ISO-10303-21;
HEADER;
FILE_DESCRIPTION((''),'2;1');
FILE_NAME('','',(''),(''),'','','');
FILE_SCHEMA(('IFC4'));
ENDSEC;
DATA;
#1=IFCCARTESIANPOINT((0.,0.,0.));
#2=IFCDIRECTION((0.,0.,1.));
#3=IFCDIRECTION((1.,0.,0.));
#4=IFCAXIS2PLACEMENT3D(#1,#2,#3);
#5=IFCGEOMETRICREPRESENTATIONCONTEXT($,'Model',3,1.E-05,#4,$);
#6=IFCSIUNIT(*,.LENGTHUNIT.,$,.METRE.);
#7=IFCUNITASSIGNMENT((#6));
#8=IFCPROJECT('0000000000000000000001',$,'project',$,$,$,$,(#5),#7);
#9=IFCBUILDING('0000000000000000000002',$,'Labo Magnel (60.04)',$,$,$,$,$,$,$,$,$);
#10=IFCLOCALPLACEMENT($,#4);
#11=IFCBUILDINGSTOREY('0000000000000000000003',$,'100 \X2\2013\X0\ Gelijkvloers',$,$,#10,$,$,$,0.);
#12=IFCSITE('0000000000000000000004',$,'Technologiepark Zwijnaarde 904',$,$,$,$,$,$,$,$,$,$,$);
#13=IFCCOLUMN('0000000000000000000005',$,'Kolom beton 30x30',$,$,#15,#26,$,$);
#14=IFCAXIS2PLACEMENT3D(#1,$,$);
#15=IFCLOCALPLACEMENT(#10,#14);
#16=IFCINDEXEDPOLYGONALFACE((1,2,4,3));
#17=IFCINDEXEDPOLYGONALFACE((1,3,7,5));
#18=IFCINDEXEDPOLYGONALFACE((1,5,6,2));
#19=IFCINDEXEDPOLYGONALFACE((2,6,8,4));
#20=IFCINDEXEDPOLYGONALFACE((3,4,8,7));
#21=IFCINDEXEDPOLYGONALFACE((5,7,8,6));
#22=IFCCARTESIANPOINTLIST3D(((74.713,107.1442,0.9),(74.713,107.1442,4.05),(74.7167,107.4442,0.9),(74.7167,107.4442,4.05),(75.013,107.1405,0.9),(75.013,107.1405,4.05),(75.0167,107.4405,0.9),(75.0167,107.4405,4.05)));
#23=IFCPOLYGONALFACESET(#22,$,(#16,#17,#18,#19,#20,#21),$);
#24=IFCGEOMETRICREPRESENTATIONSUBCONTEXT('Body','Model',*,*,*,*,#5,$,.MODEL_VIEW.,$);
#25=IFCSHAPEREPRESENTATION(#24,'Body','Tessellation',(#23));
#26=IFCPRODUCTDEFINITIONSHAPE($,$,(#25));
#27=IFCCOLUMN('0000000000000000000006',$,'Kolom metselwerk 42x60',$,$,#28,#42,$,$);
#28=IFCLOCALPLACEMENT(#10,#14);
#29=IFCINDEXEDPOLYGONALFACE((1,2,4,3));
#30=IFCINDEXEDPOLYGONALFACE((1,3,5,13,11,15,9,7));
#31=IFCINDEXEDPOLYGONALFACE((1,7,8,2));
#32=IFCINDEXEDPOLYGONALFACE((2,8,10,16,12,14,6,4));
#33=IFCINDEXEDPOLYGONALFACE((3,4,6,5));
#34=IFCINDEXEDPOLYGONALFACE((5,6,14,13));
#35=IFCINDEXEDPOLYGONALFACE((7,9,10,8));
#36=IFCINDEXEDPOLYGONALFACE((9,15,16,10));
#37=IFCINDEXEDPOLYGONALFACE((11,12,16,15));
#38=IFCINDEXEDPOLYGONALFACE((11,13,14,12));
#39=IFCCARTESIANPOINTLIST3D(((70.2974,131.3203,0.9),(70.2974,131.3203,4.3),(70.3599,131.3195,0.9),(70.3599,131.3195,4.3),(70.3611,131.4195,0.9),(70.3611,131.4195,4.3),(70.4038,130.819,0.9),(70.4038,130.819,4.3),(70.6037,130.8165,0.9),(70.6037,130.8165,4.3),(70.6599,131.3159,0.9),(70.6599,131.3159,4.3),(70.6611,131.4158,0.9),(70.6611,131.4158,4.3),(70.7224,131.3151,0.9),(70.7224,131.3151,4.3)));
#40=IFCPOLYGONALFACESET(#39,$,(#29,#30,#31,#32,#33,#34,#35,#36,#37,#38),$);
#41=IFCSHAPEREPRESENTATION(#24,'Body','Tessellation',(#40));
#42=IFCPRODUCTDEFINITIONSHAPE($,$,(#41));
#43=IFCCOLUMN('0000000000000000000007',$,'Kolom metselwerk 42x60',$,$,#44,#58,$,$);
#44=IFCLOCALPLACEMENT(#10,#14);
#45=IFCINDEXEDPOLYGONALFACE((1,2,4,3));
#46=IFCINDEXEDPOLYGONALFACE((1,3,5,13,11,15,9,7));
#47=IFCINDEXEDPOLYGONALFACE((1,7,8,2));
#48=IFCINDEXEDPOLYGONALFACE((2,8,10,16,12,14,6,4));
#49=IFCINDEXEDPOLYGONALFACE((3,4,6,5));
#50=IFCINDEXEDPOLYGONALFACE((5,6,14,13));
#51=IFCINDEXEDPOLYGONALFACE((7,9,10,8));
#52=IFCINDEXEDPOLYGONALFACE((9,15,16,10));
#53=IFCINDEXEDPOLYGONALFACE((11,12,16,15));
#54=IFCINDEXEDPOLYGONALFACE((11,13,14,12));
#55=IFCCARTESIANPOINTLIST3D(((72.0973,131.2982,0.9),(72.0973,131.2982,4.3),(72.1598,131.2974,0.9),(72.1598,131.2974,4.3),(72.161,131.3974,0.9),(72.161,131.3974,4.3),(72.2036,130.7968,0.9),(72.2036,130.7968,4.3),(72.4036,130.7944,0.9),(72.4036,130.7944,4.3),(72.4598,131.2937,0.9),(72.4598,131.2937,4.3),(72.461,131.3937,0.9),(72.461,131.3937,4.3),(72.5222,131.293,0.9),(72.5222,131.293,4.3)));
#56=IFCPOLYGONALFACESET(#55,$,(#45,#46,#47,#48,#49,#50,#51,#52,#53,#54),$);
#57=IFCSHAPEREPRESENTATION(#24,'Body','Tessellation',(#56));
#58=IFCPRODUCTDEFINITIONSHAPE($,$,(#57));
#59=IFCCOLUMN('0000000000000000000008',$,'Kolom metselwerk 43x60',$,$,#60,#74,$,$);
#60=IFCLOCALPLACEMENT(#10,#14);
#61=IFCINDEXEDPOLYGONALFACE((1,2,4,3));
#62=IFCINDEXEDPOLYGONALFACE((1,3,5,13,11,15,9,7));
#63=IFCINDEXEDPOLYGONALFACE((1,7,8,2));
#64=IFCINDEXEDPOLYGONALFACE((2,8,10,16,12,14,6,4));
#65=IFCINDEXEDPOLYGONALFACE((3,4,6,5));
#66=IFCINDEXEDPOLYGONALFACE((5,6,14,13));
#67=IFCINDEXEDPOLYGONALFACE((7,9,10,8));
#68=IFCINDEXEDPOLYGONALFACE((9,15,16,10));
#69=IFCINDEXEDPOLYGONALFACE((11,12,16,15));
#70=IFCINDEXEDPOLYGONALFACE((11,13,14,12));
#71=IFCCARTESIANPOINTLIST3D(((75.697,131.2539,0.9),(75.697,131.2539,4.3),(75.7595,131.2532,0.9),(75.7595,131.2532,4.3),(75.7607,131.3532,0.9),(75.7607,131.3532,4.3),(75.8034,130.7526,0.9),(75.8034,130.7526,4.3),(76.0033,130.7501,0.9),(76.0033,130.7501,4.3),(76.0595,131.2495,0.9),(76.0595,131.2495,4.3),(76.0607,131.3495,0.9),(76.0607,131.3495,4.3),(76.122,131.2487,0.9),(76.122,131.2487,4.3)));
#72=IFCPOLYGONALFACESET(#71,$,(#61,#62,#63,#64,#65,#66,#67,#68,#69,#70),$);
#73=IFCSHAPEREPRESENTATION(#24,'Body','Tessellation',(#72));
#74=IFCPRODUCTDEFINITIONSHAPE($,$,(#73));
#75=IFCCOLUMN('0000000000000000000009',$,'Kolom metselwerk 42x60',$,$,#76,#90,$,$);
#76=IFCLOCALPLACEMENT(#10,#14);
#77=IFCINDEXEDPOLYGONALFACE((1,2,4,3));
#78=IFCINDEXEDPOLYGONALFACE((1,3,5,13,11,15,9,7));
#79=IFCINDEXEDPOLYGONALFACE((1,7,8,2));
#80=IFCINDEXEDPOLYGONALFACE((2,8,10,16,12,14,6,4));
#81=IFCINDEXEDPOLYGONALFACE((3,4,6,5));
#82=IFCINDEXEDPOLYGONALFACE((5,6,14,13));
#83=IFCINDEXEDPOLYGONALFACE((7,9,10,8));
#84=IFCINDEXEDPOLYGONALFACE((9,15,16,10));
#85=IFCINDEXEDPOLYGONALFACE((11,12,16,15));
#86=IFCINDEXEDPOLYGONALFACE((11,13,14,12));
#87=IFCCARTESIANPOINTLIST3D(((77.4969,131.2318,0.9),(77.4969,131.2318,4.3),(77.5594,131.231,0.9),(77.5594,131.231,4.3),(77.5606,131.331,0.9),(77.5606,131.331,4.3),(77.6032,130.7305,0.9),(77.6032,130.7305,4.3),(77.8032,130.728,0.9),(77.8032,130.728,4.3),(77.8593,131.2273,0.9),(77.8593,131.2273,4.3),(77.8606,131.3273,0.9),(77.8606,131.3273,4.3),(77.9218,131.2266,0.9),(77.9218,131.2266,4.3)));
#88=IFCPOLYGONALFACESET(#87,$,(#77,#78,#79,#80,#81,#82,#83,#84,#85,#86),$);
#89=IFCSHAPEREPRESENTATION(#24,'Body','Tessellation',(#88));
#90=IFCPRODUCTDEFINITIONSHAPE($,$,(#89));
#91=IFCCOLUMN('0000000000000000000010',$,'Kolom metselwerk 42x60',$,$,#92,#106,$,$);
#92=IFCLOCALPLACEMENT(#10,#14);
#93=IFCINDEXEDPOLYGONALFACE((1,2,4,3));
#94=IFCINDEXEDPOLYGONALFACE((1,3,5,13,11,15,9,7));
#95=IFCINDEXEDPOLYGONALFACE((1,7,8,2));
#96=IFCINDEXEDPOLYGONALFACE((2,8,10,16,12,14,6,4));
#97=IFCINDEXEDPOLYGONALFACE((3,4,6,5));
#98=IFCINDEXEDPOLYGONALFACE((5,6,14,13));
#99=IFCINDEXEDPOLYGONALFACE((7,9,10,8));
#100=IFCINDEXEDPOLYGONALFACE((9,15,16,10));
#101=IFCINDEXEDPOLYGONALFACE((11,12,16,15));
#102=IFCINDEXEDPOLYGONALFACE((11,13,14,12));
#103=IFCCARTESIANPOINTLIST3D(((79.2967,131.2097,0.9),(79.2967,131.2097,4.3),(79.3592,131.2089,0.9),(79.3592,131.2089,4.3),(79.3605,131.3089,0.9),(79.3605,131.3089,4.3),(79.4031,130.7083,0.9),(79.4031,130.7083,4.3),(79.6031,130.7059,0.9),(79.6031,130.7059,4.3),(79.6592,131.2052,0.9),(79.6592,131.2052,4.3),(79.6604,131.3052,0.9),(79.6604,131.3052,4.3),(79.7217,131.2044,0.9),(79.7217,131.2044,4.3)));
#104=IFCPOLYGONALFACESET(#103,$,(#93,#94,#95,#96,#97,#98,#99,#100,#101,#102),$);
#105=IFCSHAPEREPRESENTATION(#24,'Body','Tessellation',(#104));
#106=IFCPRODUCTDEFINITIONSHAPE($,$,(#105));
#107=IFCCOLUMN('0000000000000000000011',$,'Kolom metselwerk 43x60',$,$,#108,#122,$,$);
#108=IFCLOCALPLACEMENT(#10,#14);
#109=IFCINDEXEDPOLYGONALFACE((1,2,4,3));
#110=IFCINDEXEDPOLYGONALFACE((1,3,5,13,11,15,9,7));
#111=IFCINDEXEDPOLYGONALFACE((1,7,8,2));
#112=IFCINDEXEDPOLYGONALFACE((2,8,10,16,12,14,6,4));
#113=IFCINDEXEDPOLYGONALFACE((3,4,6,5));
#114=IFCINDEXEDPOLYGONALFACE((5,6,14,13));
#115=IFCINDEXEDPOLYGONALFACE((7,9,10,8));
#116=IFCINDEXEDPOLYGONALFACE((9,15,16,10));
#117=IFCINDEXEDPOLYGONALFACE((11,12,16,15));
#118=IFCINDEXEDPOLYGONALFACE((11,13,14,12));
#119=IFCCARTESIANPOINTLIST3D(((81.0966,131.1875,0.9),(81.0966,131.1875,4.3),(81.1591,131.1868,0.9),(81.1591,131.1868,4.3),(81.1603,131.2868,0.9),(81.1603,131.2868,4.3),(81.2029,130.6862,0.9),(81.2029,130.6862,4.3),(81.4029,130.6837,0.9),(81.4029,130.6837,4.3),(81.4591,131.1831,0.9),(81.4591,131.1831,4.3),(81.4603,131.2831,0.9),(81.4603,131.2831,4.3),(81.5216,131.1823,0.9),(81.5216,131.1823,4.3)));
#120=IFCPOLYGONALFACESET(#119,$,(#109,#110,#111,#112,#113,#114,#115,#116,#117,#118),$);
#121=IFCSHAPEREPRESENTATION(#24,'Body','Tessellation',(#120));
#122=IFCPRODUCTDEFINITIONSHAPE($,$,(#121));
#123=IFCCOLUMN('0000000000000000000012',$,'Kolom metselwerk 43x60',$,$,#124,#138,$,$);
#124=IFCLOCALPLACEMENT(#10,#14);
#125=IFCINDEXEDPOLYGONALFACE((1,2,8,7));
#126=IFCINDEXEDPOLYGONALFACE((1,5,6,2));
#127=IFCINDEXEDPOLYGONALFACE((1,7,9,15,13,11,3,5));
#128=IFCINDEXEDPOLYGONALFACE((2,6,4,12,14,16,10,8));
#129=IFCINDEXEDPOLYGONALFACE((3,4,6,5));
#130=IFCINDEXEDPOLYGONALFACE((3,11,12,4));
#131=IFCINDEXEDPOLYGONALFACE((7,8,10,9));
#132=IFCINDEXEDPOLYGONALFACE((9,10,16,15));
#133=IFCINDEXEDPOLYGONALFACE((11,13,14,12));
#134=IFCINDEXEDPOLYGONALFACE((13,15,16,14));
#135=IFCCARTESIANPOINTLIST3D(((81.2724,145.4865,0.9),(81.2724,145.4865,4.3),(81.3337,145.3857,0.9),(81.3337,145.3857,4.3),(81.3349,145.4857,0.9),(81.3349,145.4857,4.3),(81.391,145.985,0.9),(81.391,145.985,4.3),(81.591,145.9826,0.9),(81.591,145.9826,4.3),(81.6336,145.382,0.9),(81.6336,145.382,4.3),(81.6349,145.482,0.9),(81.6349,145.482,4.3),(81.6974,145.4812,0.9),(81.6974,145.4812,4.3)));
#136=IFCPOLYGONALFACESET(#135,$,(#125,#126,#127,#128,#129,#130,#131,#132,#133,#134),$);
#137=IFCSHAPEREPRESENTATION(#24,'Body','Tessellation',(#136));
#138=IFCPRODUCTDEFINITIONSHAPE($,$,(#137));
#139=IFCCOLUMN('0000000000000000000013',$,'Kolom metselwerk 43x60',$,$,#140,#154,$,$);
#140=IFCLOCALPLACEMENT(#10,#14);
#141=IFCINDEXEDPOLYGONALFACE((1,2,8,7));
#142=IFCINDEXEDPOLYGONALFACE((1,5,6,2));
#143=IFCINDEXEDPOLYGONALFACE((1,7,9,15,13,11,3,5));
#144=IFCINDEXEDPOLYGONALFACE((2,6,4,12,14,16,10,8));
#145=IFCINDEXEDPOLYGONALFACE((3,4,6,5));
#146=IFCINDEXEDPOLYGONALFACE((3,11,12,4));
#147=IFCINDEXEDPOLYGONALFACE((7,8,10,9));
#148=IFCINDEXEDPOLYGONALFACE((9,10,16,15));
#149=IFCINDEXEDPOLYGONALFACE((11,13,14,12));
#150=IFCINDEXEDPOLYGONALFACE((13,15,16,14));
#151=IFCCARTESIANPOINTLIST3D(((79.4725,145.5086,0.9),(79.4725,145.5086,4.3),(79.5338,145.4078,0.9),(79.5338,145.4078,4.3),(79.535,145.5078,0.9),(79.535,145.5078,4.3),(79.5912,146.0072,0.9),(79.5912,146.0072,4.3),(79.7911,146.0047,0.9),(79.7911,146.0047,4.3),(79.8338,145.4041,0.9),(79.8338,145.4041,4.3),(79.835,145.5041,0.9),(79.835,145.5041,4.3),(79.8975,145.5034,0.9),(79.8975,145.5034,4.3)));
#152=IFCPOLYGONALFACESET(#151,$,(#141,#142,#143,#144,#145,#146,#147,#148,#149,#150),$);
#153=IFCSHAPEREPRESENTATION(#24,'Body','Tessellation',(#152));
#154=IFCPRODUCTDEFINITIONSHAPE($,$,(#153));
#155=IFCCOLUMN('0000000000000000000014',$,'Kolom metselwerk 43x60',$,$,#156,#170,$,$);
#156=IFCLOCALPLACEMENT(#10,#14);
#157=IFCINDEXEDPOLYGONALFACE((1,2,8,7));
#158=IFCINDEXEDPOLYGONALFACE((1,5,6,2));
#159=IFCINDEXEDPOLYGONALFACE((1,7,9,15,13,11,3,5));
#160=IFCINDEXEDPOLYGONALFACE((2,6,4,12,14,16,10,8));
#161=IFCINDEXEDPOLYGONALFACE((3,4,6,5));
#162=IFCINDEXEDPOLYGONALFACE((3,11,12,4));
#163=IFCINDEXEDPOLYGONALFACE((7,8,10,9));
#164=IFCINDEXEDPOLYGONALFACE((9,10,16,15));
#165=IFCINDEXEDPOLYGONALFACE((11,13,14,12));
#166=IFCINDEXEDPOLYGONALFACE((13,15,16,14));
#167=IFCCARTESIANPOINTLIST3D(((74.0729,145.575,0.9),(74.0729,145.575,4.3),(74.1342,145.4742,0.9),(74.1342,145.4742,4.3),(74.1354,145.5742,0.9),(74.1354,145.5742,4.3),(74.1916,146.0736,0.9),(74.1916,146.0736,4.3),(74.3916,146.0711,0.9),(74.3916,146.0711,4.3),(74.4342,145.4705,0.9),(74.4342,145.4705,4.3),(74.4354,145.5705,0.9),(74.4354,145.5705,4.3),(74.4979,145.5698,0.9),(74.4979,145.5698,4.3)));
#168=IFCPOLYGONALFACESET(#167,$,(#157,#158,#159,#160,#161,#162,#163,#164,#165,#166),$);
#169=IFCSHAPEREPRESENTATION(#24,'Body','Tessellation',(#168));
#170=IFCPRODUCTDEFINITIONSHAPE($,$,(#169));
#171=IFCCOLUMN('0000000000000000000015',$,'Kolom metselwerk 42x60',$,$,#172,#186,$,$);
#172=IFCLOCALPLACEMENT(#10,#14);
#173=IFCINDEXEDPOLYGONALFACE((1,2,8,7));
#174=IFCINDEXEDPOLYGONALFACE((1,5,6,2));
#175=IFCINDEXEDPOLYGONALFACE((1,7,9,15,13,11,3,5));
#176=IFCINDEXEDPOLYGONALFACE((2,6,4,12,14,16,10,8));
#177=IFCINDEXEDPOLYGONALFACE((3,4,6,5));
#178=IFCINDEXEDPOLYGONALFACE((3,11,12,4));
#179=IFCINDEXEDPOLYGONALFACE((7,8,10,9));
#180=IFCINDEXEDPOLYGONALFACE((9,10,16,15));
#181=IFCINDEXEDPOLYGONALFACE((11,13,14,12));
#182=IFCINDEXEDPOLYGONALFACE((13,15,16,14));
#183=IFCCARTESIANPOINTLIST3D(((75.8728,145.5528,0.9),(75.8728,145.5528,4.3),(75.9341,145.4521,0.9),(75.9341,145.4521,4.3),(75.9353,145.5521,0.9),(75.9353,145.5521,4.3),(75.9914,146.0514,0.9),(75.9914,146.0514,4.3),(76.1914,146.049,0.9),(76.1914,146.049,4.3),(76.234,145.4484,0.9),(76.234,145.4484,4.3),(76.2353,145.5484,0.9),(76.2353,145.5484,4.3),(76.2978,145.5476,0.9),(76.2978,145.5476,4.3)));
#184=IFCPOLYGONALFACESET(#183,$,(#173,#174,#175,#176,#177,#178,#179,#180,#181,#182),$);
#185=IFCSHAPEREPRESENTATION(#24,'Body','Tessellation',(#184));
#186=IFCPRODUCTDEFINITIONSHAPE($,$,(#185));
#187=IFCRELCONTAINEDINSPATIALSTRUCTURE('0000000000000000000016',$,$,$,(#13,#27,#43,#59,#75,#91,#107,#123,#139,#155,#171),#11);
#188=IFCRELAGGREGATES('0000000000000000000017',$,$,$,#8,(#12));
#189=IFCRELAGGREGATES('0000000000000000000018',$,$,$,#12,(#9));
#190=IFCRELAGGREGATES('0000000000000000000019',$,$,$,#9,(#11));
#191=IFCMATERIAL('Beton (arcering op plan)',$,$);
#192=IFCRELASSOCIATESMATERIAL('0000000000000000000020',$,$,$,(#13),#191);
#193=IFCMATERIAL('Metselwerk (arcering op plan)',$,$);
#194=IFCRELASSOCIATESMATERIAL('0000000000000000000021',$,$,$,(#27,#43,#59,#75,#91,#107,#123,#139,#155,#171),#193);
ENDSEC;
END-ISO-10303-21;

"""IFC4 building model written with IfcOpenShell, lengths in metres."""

from ifc_helpers import new_model, si_unit, frame, origin, origin_with_axes, place, context, subcontext, project, spatial, polyline, outline, extrude, material, element, save


model = new_model("IFC4")

# Units and contexts
model_context = context("Model", 3, precision=1e-05, world=origin_with_axes())
body_context = subcontext(model_context, "Body", "Model", "MODEL_VIEW")
ifc_project = project(units=[si_unit("LENGTHUNIT", "METRE")], contexts=[model_context])

# Site, building, storey
site = spatial("IfcSite", under=ifc_project, Name="Technologiepark Zwijnaarde 904")
building = spatial("IfcBuilding", under=site, Name="Labo Magnel (60.04)")
storey_placement = place(None, origin_with_axes())
storey = spatial("IfcBuildingStorey", under=building, at=storey_placement, Name="100 – Gelijkvloers", Elevation=0.0)

# Columns
ifc_material_1 = material(Name="Beton (arcering op plan)")
column_1_placement = place(storey_placement, frame((0.0, 0.0, 0.9), z_axis=(0.0, 0.0, 1.0), x_axis=(1.0, 0.0, 0.0)))
element("IfcColumn", 1, at=column_1_placement, inside=storey, material=ifc_material_1, Name="Kolom beton 30x30", context=body_context, shape_type="SweptSolid", body=[
    extrude(outline(polyline([(75.0167, 107.4405), (74.7167, 107.4442), (74.713, 107.1442), (75.013, 107.1405), (75.0167, 107.4405)])), origin(), (0.0, 0.0, 1.0), 3.15),
])
ifc_material_2 = material(Name="Metselwerk (arcering op plan)")
column_2_placement = place(storey_placement, frame((0.0, 0.0, 0.9), z_axis=(0.0, 0.0, 1.0), x_axis=(1.0, 0.0, 0.0)))
element("IfcColumn", 2, at=column_2_placement, inside=storey, material=ifc_material_2, Name="Kolom metselwerk 42x60", context=body_context, shape_type="SweptSolid", body=[
    extrude(outline(polyline([(70.7224, 131.3151), (70.6599, 131.3159), (70.6611, 131.4158), (70.3611, 131.4195), (70.3599, 131.3195), (70.2974, 131.3203), (70.4038, 130.819), (70.6037, 130.8165), (70.7224, 131.3151)])), origin(), (0.0, 0.0, 1.0), 3.4),
])
column_3_placement = place(storey_placement, frame((0.0, 0.0, 0.9), z_axis=(0.0, 0.0, 1.0), x_axis=(1.0, 0.0, 0.0)))
element("IfcColumn", 3, at=column_3_placement, inside=storey, material=ifc_material_2, Name="Kolom metselwerk 42x60", context=body_context, shape_type="SweptSolid", body=[
    extrude(outline(polyline([(72.5222, 131.293), (72.4598, 131.2937), (72.461, 131.3937), (72.161, 131.3974), (72.1598, 131.2974), (72.0973, 131.2982), (72.2036, 130.7968), (72.4036, 130.7944), (72.5222, 131.293)])), origin(), (0.0, 0.0, 1.0), 3.4),
])
column_4_placement = place(storey_placement, frame((0.0, 0.0, 0.9), z_axis=(0.0, 0.0, 1.0), x_axis=(1.0, 0.0, 0.0)))
element("IfcColumn", 4, at=column_4_placement, inside=storey, material=ifc_material_2, Name="Kolom metselwerk 43x60", context=body_context, shape_type="SweptSolid", body=[
    extrude(outline(polyline([(76.122, 131.2487), (76.0595, 131.2495), (76.0607, 131.3495), (75.7607, 131.3532), (75.7595, 131.2532), (75.697, 131.2539), (75.8034, 130.7526), (76.0033, 130.7501), (76.122, 131.2487)])), origin(), (0.0, 0.0, 1.0), 3.4),
])
column_5_placement = place(storey_placement, frame((0.0, 0.0, 0.9), z_axis=(0.0, 0.0, 1.0), x_axis=(1.0, 0.0, 0.0)))
element("IfcColumn", 5, at=column_5_placement, inside=storey, material=ifc_material_2, Name="Kolom metselwerk 42x60", context=body_context, shape_type="SweptSolid", body=[
    extrude(outline(polyline([(77.9218, 131.2266), (77.8593, 131.2273), (77.8606, 131.3273), (77.5606, 131.331), (77.5594, 131.231), (77.4969, 131.2318), (77.6032, 130.7305), (77.8032, 130.728), (77.9218, 131.2266)])), origin(), (0.0, 0.0, 1.0), 3.4),
])
column_6_placement = place(storey_placement, frame((0.0, 0.0, 0.9), z_axis=(0.0, 0.0, 1.0), x_axis=(1.0, 0.0, 0.0)))
element("IfcColumn", 6, at=column_6_placement, inside=storey, material=ifc_material_2, Name="Kolom metselwerk 42x60", context=body_context, shape_type="SweptSolid", body=[
    extrude(outline(polyline([(79.7217, 131.2044), (79.6592, 131.2052), (79.6604, 131.3052), (79.3605, 131.3089), (79.3592, 131.2089), (79.2967, 131.2097), (79.4031, 130.7083), (79.6031, 130.7059), (79.7217, 131.2044)])), origin(), (0.0, 0.0, 1.0), 3.4),
])
column_7_placement = place(storey_placement, frame((0.0, 0.0, 0.9), z_axis=(0.0, 0.0, 1.0), x_axis=(1.0, 0.0, 0.0)))
element("IfcColumn", 7, at=column_7_placement, inside=storey, material=ifc_material_2, Name="Kolom metselwerk 43x60", context=body_context, shape_type="SweptSolid", body=[
    extrude(outline(polyline([(81.5216, 131.1823), (81.4591, 131.1831), (81.4603, 131.2831), (81.1603, 131.2868), (81.1591, 131.1868), (81.0966, 131.1875), (81.2029, 130.6862), (81.4029, 130.6837), (81.5216, 131.1823)])), origin(), (0.0, 0.0, 1.0), 3.4),
])
column_8_placement = place(storey_placement, frame((0.0, 0.0, 0.9), z_axis=(0.0, 0.0, 1.0), x_axis=(1.0, 0.0, 0.0)))
element("IfcColumn", 8, at=column_8_placement, inside=storey, material=ifc_material_2, Name="Kolom metselwerk 43x60", context=body_context, shape_type="SweptSolid", body=[
    extrude(outline(polyline([(81.591, 145.9826), (81.391, 145.985), (81.2724, 145.4865), (81.3349, 145.4857), (81.3337, 145.3857), (81.6336, 145.382), (81.6349, 145.482), (81.6974, 145.4812), (81.591, 145.9826)])), origin(), (0.0, 0.0, 1.0), 3.4),
])
column_9_placement = place(storey_placement, frame((0.0, 0.0, 0.9), z_axis=(0.0, 0.0, 1.0), x_axis=(1.0, 0.0, 0.0)))
element("IfcColumn", 9, at=column_9_placement, inside=storey, material=ifc_material_2, Name="Kolom metselwerk 43x60", context=body_context, shape_type="SweptSolid", body=[
    extrude(outline(polyline([(79.7911, 146.0047), (79.5912, 146.0072), (79.4725, 145.5086), (79.535, 145.5078), (79.5338, 145.4078), (79.8338, 145.4041), (79.835, 145.5041), (79.8975, 145.5034), (79.7911, 146.0047)])), origin(), (0.0, 0.0, 1.0), 3.4),
])
column_10_placement = place(storey_placement, frame((0.0, 0.0, 0.9), z_axis=(0.0, 0.0, 1.0), x_axis=(1.0, 0.0, 0.0)))
element("IfcColumn", 10, at=column_10_placement, inside=storey, material=ifc_material_2, Name="Kolom metselwerk 43x60", context=body_context, shape_type="SweptSolid", body=[
    extrude(outline(polyline([(74.3916, 146.0711), (74.1916, 146.0736), (74.0729, 145.575), (74.1354, 145.5742), (74.1342, 145.4742), (74.4342, 145.4705), (74.4354, 145.5705), (74.4979, 145.5698), (74.3916, 146.0711)])), origin(), (0.0, 0.0, 1.0), 3.4),
])
column_11_placement = place(storey_placement, frame((0.0, 0.0, 0.9), z_axis=(0.0, 0.0, 1.0), x_axis=(1.0, 0.0, 0.0)))
element("IfcColumn", 11, at=column_11_placement, inside=storey, material=ifc_material_2, Name="Kolom metselwerk 42x60", context=body_context, shape_type="SweptSolid", body=[
    extrude(outline(polyline([(76.1914, 146.049), (75.9914, 146.0514), (75.8728, 145.5528), (75.9353, 145.5521), (75.9341, 145.4521), (76.234, 145.4484), (76.2353, 145.5484), (76.2978, 145.5476), (76.1914, 146.049)])), origin(), (0.0, 0.0, 1.0), 3.4),
])

save(model, "model.ifc")
